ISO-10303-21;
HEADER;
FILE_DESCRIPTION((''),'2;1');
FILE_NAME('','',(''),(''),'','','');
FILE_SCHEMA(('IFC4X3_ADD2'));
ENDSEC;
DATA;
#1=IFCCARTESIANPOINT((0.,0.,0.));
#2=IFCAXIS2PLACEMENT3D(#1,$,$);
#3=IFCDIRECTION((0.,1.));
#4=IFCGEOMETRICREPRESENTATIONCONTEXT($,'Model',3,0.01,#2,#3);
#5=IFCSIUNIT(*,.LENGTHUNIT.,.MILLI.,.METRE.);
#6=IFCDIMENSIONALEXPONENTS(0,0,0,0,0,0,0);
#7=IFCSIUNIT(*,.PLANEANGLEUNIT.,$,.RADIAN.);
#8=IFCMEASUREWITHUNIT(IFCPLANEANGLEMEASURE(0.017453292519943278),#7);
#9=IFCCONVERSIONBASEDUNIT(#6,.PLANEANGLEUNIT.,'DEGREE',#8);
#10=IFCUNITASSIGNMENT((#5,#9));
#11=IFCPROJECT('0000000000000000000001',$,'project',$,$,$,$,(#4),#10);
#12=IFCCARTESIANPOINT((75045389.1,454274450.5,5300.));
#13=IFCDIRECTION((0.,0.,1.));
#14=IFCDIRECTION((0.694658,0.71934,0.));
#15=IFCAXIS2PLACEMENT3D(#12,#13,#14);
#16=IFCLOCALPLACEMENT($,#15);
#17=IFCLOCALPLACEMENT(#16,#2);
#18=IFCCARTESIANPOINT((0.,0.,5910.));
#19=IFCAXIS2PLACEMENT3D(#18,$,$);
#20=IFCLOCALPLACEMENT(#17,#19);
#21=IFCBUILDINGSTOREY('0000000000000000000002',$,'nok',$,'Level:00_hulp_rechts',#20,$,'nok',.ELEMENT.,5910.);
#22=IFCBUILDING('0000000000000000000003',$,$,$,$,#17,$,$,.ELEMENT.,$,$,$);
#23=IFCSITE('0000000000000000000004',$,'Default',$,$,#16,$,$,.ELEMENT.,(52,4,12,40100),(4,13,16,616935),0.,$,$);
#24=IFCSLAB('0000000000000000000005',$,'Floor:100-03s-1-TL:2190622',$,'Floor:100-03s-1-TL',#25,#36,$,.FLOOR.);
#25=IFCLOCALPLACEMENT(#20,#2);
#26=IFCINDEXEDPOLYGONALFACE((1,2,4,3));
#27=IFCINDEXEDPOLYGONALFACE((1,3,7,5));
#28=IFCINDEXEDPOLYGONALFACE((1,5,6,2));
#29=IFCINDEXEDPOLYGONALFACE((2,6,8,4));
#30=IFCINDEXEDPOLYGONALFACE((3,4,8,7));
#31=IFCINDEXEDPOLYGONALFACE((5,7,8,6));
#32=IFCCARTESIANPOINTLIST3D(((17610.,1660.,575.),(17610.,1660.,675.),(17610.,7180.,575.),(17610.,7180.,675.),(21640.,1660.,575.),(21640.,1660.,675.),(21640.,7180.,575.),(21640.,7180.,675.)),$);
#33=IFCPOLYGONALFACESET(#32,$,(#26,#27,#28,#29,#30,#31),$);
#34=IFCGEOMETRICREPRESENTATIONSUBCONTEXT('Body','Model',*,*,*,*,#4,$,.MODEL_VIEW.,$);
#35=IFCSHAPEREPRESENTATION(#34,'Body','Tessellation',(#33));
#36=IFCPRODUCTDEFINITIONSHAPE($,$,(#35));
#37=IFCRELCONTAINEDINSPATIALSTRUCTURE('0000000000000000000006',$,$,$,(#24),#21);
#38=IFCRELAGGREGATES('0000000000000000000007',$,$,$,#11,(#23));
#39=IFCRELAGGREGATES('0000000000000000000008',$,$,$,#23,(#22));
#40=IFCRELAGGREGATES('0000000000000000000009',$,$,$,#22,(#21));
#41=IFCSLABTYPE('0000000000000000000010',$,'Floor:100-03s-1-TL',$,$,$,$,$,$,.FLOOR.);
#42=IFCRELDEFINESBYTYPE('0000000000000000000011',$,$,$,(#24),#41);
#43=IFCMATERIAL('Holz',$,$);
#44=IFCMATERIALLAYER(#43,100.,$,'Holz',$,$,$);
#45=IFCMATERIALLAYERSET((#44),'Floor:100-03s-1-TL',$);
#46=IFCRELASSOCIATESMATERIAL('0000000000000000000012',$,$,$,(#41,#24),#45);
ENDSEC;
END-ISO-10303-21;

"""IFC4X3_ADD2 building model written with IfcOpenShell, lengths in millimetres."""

from ifc_helpers import new_model, entity, si_unit, converted_unit, direction, frame, frame_2d, origin, place, context, subcontext, project, spatial, rectangle, extrude, material, layer, layer_set, layer_usage, type_object, element, save


model = new_model("IFC4X3_ADD2")

# Units and contexts
model_context = context("Model", 3, precision=0.01, world=origin(), true_north=direction((0.0, 1.0)))
body_context = subcontext(model_context, "Body", "Model", "MODEL_VIEW")
ifc_project = project(units=[si_unit("LENGTHUNIT", "METRE", prefix="MILLI"), converted_unit("PLANEANGLEUNIT", "DEGREE", entity("IfcPlaneAngleMeasure", 0.017453292519943278), si_unit("PLANEANGLEUNIT", "RADIAN"), dimensions=[0, 0, 0, 0, 0, 0, 0])], contexts=[model_context])

# Site, building, storey
site_placement = place(None, frame((75045389.1, 454274450.5, 5300.0), z_axis=(0.0, 0.0, 1.0), x_axis=(0.694658, 0.71934, 0.0)))
site = spatial("IfcSite", under=ifc_project, at=site_placement, Name="Default", CompositionType="ELEMENT", RefLatitude=(52, 4, 12, 40100), RefLongitude=(4, 13, 16, 616935), RefElevation=0.0)
building_placement = place(site_placement, origin())
building = spatial("IfcBuilding", under=site, at=building_placement, CompositionType="ELEMENT")
storey_placement = place(building_placement, frame((0.0, 0.0, 5910.0)))
storey = spatial("IfcBuildingStorey", under=building, at=storey_placement, Name="nok", ObjectType="Level:00_hulp_rechts", LongName="nok", CompositionType="ELEMENT", Elevation=5910.0)

# Slab
ifc_material = material(Name="Holz")
ifc_layer = layer(ifc_material, 100.0, Name="Holz")
ifc_layer_set = layer_set([ifc_layer], Name="Floor:100-03s-1-TL")
ifc_layer_usage = layer_usage(ifc_layer_set, "AXIS3", "POSITIVE", 0.0)
slab_type = type_object("IfcSlabType", Name="Floor:100-03s-1-TL", PredefinedType="FLOOR", material=ifc_layer_set)
slab_placement = place(storey_placement, origin())
element("IfcSlab", 1, at=slab_placement, inside=storey, type_object=slab_type, material=ifc_layer_usage, Name="Floor:100-03s-1-TL:2190622", ObjectType="Floor:100-03s-1-TL", PredefinedType="FLOOR", context=body_context, shape_type="SweptSolid", body=[
    extrude(rectangle(XDim=5520.0, YDim=4030.0, at=frame_2d((0.0, 0.0), x_axis=(1.0, 0.0))), frame((19625.0, 4420.0, 675.0), z_axis=(0.0, 0.0, -1.0), x_axis=(0.0, 1.0, 0.0)), (0.0, 0.0, 1.0), 100.0),
])

save(model, "model.ifc")
